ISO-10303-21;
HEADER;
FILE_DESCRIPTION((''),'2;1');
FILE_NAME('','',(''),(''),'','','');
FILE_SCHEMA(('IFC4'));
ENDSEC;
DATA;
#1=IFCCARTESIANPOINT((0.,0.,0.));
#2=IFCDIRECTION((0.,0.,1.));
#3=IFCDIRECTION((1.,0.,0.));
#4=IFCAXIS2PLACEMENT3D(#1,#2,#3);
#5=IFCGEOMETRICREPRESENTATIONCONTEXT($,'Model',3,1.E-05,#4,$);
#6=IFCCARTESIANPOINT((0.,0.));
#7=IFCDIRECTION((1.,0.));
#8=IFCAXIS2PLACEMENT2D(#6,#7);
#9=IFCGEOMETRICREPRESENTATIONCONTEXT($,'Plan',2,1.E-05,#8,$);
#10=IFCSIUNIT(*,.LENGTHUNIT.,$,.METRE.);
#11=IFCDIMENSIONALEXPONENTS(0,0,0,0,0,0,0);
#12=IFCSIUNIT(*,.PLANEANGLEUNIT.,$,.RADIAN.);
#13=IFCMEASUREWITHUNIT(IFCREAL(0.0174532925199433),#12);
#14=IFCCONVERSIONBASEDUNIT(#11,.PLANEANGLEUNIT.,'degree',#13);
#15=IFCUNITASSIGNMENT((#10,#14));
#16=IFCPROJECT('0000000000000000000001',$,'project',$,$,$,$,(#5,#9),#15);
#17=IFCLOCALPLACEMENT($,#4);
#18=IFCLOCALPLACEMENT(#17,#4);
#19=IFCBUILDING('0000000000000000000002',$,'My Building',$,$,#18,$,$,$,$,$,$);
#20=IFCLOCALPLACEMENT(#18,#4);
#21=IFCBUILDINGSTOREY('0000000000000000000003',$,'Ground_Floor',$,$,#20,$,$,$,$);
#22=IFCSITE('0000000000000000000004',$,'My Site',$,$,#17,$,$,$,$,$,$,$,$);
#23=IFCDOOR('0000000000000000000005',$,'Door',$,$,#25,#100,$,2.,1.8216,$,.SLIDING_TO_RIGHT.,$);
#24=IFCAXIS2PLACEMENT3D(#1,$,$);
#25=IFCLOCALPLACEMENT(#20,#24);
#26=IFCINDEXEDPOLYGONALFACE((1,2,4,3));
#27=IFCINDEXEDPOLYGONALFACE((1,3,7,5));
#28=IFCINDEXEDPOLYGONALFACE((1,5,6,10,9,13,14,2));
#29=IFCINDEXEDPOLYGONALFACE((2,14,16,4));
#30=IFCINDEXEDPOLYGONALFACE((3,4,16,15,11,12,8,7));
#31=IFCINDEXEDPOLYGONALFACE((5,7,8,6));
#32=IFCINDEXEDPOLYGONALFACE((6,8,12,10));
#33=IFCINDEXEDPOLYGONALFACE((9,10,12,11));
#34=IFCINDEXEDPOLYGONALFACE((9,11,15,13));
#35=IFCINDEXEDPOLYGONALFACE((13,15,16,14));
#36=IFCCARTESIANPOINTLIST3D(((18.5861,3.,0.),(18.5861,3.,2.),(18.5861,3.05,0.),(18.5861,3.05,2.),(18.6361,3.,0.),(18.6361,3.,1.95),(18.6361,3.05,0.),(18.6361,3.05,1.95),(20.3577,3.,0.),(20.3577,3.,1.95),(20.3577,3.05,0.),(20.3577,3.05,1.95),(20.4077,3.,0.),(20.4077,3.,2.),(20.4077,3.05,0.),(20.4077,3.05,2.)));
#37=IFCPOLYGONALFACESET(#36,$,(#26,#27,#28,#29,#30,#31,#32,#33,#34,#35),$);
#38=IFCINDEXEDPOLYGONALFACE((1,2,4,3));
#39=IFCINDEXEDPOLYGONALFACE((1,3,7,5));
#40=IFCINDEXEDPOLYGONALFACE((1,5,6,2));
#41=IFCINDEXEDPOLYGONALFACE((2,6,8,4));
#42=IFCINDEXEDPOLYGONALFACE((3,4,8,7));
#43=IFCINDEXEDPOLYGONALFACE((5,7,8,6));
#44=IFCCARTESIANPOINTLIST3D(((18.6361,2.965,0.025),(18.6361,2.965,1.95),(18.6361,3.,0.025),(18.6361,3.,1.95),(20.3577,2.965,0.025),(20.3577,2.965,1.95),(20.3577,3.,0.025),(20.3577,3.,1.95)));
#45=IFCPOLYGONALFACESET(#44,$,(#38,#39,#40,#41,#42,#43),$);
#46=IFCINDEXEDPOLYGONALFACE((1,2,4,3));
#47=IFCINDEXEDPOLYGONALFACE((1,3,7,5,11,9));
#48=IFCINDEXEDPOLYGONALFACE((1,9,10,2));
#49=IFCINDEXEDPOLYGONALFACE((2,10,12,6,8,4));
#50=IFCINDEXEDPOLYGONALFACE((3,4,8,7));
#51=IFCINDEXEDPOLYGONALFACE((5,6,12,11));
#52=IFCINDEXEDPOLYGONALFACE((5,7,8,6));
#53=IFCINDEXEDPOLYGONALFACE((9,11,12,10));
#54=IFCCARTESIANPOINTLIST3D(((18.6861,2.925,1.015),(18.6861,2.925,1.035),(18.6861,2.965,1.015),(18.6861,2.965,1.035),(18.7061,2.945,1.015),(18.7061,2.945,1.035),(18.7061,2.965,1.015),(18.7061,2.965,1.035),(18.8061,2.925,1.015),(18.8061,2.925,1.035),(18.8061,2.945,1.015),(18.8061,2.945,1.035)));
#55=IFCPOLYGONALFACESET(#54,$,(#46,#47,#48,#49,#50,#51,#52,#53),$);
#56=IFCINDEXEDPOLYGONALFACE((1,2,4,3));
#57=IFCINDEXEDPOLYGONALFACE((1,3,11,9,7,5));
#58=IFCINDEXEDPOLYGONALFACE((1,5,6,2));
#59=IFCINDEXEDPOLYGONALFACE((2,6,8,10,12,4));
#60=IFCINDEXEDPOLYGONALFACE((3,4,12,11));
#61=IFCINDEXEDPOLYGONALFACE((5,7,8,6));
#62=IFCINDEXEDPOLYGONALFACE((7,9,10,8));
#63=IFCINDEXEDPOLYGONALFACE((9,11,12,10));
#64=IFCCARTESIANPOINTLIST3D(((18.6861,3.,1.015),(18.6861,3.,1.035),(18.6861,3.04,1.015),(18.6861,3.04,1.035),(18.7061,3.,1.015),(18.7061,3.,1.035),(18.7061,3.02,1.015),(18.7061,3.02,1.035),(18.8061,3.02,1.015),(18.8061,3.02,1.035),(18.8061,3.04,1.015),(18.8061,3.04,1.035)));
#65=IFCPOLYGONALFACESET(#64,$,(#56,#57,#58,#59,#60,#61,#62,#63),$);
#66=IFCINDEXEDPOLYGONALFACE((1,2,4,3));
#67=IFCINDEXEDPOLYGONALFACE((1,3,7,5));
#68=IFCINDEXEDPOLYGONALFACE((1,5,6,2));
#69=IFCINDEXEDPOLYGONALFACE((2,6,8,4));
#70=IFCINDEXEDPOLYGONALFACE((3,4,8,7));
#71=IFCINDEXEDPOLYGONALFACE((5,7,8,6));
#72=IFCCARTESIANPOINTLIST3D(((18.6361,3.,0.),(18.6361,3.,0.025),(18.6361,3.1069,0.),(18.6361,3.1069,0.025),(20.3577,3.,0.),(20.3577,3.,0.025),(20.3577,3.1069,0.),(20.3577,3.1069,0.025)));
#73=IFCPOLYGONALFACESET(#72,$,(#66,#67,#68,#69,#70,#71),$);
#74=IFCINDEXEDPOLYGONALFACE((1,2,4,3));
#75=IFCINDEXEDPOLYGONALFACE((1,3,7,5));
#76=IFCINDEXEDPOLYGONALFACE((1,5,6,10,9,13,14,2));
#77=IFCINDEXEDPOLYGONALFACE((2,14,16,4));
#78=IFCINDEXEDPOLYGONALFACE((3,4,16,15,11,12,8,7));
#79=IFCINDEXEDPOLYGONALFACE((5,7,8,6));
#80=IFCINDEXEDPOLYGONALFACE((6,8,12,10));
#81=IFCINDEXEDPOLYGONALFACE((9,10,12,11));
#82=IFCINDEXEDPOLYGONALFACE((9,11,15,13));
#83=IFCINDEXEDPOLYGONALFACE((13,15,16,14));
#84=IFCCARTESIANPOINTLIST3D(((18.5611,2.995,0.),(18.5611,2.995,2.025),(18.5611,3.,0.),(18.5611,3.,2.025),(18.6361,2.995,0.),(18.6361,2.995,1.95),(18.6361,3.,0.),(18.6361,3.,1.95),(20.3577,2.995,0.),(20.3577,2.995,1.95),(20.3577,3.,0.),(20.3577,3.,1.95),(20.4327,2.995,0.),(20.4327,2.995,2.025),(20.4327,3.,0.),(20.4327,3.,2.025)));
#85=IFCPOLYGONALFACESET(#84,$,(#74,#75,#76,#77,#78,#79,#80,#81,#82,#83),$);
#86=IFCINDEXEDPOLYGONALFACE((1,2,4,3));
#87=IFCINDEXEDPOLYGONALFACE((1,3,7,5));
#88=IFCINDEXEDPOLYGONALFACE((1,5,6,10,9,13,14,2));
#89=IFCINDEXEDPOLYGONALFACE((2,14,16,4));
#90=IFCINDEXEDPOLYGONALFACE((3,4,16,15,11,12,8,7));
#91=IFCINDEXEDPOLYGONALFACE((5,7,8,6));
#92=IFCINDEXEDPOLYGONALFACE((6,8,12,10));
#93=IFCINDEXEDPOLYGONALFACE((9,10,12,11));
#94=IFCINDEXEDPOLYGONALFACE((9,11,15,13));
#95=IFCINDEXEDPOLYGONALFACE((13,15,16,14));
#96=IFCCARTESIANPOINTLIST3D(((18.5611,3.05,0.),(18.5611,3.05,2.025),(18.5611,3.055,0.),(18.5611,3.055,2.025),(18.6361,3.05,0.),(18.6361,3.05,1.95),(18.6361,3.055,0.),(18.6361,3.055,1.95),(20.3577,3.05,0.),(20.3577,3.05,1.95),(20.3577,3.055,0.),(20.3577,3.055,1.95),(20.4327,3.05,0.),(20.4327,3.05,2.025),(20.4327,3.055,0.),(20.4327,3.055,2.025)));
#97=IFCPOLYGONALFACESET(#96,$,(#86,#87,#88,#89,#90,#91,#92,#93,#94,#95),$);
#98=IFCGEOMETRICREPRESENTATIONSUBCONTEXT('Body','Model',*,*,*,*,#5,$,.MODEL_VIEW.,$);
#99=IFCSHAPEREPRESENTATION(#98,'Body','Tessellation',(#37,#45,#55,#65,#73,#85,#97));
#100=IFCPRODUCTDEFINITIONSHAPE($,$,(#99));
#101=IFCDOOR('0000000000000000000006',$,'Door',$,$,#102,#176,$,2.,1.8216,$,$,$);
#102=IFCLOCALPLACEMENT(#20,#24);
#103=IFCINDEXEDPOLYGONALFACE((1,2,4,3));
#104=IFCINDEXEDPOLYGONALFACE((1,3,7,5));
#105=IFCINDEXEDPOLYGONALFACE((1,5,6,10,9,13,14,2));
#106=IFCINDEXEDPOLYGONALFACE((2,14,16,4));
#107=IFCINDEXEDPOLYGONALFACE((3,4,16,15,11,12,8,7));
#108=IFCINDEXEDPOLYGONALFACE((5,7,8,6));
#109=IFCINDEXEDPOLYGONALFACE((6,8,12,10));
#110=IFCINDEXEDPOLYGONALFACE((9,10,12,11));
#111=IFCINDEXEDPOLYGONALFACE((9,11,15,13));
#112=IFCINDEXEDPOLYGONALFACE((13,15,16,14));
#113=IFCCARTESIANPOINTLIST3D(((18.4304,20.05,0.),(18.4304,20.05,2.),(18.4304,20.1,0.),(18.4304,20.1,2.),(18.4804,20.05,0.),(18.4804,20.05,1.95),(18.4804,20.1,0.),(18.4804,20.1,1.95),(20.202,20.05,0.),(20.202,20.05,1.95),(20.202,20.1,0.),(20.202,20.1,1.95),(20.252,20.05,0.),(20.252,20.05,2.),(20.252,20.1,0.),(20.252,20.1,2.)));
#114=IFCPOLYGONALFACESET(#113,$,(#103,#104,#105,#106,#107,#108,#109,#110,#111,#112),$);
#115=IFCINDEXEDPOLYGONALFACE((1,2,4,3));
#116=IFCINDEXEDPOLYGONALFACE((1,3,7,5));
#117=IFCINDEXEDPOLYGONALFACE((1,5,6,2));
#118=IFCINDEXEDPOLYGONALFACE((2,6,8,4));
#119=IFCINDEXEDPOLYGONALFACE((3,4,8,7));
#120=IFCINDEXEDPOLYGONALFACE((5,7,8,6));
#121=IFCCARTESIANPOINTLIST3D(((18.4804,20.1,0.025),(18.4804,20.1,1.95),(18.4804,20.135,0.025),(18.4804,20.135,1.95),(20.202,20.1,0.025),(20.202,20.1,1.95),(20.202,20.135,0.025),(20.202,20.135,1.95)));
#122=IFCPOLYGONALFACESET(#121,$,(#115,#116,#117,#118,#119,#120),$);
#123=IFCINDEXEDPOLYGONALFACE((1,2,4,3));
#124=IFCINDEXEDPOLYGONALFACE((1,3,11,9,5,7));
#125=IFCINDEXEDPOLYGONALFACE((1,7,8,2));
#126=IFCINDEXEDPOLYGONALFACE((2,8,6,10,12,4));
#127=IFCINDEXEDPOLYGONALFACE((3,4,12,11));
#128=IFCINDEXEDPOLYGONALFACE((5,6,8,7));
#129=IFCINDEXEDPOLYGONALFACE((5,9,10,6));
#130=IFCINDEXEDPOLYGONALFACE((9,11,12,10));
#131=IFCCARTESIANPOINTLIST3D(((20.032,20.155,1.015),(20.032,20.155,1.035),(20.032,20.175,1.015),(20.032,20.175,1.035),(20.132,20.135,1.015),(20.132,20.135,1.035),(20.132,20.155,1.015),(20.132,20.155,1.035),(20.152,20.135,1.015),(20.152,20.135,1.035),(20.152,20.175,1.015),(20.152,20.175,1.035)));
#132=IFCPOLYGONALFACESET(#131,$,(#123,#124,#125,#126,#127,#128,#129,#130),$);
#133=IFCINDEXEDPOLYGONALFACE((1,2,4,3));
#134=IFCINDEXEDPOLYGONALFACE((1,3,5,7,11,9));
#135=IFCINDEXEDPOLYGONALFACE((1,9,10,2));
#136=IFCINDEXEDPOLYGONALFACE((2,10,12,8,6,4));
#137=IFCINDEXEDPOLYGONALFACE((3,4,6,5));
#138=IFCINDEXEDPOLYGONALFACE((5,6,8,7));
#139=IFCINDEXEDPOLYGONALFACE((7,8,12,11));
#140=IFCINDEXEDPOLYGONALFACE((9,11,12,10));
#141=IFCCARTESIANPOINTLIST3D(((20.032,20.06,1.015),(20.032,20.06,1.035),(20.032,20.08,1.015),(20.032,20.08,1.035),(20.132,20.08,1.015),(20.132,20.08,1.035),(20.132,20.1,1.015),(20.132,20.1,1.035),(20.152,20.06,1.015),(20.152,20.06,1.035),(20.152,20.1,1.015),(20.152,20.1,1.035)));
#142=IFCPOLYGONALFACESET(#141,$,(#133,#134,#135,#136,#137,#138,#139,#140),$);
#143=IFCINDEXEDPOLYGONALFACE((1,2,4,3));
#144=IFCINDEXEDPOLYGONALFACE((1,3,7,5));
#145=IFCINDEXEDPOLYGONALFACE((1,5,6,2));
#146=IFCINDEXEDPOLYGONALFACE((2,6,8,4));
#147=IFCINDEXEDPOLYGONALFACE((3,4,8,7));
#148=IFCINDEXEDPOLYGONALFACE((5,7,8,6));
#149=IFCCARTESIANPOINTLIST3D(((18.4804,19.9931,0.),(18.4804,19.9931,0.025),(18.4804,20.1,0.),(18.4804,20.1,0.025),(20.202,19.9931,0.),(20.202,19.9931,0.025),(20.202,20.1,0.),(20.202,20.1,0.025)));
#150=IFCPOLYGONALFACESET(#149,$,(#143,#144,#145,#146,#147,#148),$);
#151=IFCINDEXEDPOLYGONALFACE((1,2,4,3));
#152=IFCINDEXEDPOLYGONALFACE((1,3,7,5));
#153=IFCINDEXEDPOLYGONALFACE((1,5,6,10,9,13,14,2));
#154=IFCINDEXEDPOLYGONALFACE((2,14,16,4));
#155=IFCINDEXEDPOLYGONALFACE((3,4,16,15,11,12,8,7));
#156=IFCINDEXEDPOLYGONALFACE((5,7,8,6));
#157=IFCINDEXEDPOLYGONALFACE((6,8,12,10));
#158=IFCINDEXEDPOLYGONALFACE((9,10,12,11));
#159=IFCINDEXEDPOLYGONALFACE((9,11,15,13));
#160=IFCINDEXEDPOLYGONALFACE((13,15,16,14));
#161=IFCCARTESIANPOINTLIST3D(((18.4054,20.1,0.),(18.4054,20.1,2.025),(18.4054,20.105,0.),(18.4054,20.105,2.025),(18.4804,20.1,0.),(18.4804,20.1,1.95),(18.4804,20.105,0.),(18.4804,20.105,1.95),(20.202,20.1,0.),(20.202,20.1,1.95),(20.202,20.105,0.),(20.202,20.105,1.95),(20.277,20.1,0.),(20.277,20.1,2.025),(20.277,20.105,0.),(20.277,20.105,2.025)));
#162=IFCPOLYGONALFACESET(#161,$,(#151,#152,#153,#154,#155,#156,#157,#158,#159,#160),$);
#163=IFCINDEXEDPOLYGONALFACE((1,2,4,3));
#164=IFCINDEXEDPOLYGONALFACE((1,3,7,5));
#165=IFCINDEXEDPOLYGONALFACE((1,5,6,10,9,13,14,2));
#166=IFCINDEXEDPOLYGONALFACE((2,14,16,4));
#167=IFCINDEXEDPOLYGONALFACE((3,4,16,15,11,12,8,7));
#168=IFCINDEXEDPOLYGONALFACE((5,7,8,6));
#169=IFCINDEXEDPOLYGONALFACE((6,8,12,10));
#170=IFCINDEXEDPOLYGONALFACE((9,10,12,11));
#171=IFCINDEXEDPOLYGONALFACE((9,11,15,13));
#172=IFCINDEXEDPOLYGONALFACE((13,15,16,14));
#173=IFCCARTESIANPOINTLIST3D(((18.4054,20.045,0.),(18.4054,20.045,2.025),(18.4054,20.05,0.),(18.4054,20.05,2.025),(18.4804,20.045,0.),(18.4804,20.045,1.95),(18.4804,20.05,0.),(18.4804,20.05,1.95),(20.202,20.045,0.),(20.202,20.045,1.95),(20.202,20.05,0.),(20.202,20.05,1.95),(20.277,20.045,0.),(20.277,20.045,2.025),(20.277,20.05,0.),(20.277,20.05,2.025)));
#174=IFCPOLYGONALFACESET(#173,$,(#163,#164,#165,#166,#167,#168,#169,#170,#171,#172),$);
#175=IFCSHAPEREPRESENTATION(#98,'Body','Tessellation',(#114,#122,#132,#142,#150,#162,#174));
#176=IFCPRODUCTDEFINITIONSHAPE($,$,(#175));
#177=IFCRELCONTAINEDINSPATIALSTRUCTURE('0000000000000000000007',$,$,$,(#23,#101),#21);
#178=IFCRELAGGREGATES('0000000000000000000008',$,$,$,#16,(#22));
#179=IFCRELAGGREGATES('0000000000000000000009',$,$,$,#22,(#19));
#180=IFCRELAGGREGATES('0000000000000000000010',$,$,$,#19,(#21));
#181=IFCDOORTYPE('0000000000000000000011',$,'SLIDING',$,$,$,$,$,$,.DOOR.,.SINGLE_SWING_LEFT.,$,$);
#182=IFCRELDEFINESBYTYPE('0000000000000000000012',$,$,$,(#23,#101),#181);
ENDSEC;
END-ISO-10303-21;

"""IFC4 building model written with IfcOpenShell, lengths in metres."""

from ifc_helpers import new_model, entity, si_unit, converted_unit, frame, origin_with_axes, origin_2d_with_axis, place, context, subcontext, project, spatial, line, indexed_curve, outline, extrude, shape, source, transform, mapped, type_object, type_shapes, element, save


model = new_model("IFC4")

# Units and contexts
model_context = context("Model", 3, precision=1e-05, world=origin_with_axes())
plan_context = context("Plan", 2, precision=1e-05, world=origin_2d_with_axis())
body_context_1 = subcontext(model_context, "Body", "Model", "MODEL_VIEW")
body_context_2 = subcontext(plan_context, "Body", "Plan", "PLAN_VIEW")
ifc_project = project(units=[si_unit("LENGTHUNIT", "METRE"), converted_unit("PLANEANGLEUNIT", "degree", entity("IfcReal", 0.0174532925199433), si_unit("PLANEANGLEUNIT", "RADIAN"), dimensions=[0, 0, 0, 0, 0, 0, 0])], contexts=[model_context, plan_context])

# Site, building, storey
site_placement = place(None, origin_with_axes())
site = spatial("IfcSite", under=ifc_project, at=site_placement, Name="My Site")
building_placement = place(site_placement, origin_with_axes())
building = spatial("IfcBuilding", under=site, at=building_placement, Name="My Building")
storey_placement = place(building_placement, origin_with_axes())
storey = spatial("IfcBuildingStorey", under=building, at=storey_placement, Name="Ground_Floor")

# Doors
door_type_1 = type_object("IfcDoorType", Name="SLIDING", OperationType="SINGLE_SWING_LEFT", PredefinedType="DOOR")
shared_shape_1 = source(origin_with_axes(), body_context_1, "Body", "SweptSolid", [
    extrude(outline(indexed_curve([(0.0, 0.0), (0.0, 2.0), (1.8216, 2.0), (1.8216, 0.0), (1.7716, 0.0), (1.7716, 1.95), (0.05, 1.95), (0.05, 0.0)], segments=[line(1, 2, 3, 4, 5, 6, 7, 8, 1)])), frame((0.0, 0.0, 0.0), z_axis=(0.0, -1.0, 0.0), x_axis=(1.0, 0.0, 0.0)), (0.0, 0.0, -1.0), 0.05),
    extrude(outline(indexed_curve([(0.0, 0.0), (1.7216, 0.0), (1.7216, 0.035), (0.0, 0.035)], segments=[line(1, 2, 3, 4, 1)])), frame((0.05, -0.035, 0.025), z_axis=(0.0, 0.0, 1.0), x_axis=(1.0, 0.0, 0.0)), (0.0, 0.0, 1.0), 1.925),
    extrude(outline(indexed_curve([(0.0, 0.0), (0.0, -0.04), (0.12, -0.04), (0.12, -0.02), (0.02, -0.02), (0.02, 0.0)], segments=[line(1, 2, 3, 4, 5, 6, 1)])), frame((0.1, -0.035, 1.015), z_axis=(0.0, 0.0, 1.0), x_axis=(1.0, 0.0, 0.0)), (0.0, 0.0, 1.0), 0.02),
    extrude(outline(indexed_curve([(0.0, 0.0), (0.0, 0.04), (0.12, 0.04), (0.12, 0.02), (0.02, 0.02), (0.02, 0.0)], segments=[line(1, 2, 3, 4, 5, 6, 1)])), frame((0.1, 0.0, 1.015), z_axis=(0.0, 0.0, 1.0), x_axis=(1.0, 0.0, 0.0)), (0.0, 0.0, 1.0), 0.02),
    extrude(outline(indexed_curve([(0.0, 0.0), (1.7216, 0.0), (1.7216, 0.1069), (0.0, 0.1069)], segments=[line(1, 2, 3, 4, 1)])), frame((0.05, 0.0, 0.0), z_axis=(0.0, 0.0, 1.0), x_axis=(1.0, 0.0, 0.0)), (0.0, 0.0, 1.0), 0.025),
    extrude(outline(indexed_curve([(0.0, 0.0), (0.0, 2.025), (1.8716, 2.025), (1.8716, 0.0), (1.7966, 0.0), (1.7966, 1.95), (0.075, 1.95), (0.075, 0.0)], segments=[line(1, 2, 3, 4, 5, 6, 7, 8, 1)])), frame((-0.025, -0.005, 0.0), z_axis=(0.0, -1.0, 0.0), x_axis=(1.0, 0.0, 0.0)), (0.0, 0.0, -1.0), 0.005),
    extrude(outline(indexed_curve([(0.0, 0.0), (0.0, 2.025), (1.8716, 2.025), (1.8716, 0.0), (1.7966, 0.0), (1.7966, 1.95), (0.075, 1.95), (0.075, 0.0)], segments=[line(1, 2, 3, 4, 5, 6, 7, 8, 1)])), frame((-0.025, 0.05, 0.0), z_axis=(0.0, -1.0, 0.0), x_axis=(1.0, 0.0, 0.0)), (0.0, 0.0, -1.0), 0.005),
])
shared_shape_2 = source(origin_with_axes(), body_context_2, "Body", "Curve2D", [
    entity("IfcIndexedPolyCurve", entity("IfcCartesianPointList2D", [[0.0, 0.0], [0.05, 0.0], [0.05, 0.05], [0.0, 0.05]]), [entity("IfcLineIndex", [1, 2, 3, 4, 1])]),
    entity("IfcIndexedPolyCurve", entity("IfcCartesianPointList2D", [[1.8216, 0.0], [1.7716, 0.0], [1.7716, 0.05], [1.8216, 0.05]]), [entity("IfcLineIndex", [1, 2, 3, 4, 1])]),
    entity("IfcIndexedPolyCurve", entity("IfcCartesianPointList2D", [[2.6325, -0.035], [0.9108, -0.035], [0.9108, 0.0], [2.6325, 0.0]]), [entity("IfcLineIndex", [1, 2, 3, 4, 1])]),
])
type_shapes(door_type_1, [shared_shape_1, shared_shape_2])
door_1_placement = place(storey_placement, frame((18.5861, 3.0, 0.0), z_axis=(0.0, 0.0, 1.0), x_axis=(1.0, 0.0, 0.0)))
element("IfcDoor", 1, at=door_1_placement, inside=storey, type_object=door_type_1, Name="Door", OperationType="SLIDING_TO_RIGHT", OverallHeight=2.0, OverallWidth=1.8216, shapes=[
    shape(body_context_1, "Body", "MappedRepresentation", [mapped(shared_shape_1, transform((0.0, 0.0, 0.0), x_axis=(1.0, 0.0, 0.0), y_axis=(0.0, 1.0, 0.0), z_axis=(0.0, 0.0, 1.0), scale=1.0))]),
    shape(body_context_2, "Body", "MappedRepresentation", [mapped(shared_shape_2, transform((0.0, 0.0, 0.0), x_axis=(1.0, 0.0, 0.0), y_axis=(0.0, 1.0, 0.0), z_axis=(0.0, 0.0, 1.0), scale=1.0))]),
])
for number, where, z_axis, x_axis, name in (
    (2, (20.252, 20.1, 0.0), (0.0, 0.0, 1.0), (-1.0, 0.0, 0.0), "Door"),
):
    element("IfcDoor", number, at=place(storey_placement, frame(where, z_axis=z_axis, x_axis=x_axis)), inside=storey, type_object=door_type_1, Name=name, OverallHeight=2.0, OverallWidth=1.8216, shapes=[
        shape(body_context_1, "Body", "MappedRepresentation", [mapped(shared_shape_1, transform((0.0, 0.0, 0.0), x_axis=(1.0, 0.0, 0.0), y_axis=(0.0, 1.0, 0.0), z_axis=(0.0, 0.0, 1.0), scale=1.0))]),
        shape(body_context_2, "Body", "MappedRepresentation", [mapped(shared_shape_2, transform((0.0, 0.0, 0.0), x_axis=(1.0, 0.0, 0.0), y_axis=(0.0, 1.0, 0.0), z_axis=(0.0, 0.0, 1.0), scale=1.0))]),
    ])

save(model, "model.ifc")
